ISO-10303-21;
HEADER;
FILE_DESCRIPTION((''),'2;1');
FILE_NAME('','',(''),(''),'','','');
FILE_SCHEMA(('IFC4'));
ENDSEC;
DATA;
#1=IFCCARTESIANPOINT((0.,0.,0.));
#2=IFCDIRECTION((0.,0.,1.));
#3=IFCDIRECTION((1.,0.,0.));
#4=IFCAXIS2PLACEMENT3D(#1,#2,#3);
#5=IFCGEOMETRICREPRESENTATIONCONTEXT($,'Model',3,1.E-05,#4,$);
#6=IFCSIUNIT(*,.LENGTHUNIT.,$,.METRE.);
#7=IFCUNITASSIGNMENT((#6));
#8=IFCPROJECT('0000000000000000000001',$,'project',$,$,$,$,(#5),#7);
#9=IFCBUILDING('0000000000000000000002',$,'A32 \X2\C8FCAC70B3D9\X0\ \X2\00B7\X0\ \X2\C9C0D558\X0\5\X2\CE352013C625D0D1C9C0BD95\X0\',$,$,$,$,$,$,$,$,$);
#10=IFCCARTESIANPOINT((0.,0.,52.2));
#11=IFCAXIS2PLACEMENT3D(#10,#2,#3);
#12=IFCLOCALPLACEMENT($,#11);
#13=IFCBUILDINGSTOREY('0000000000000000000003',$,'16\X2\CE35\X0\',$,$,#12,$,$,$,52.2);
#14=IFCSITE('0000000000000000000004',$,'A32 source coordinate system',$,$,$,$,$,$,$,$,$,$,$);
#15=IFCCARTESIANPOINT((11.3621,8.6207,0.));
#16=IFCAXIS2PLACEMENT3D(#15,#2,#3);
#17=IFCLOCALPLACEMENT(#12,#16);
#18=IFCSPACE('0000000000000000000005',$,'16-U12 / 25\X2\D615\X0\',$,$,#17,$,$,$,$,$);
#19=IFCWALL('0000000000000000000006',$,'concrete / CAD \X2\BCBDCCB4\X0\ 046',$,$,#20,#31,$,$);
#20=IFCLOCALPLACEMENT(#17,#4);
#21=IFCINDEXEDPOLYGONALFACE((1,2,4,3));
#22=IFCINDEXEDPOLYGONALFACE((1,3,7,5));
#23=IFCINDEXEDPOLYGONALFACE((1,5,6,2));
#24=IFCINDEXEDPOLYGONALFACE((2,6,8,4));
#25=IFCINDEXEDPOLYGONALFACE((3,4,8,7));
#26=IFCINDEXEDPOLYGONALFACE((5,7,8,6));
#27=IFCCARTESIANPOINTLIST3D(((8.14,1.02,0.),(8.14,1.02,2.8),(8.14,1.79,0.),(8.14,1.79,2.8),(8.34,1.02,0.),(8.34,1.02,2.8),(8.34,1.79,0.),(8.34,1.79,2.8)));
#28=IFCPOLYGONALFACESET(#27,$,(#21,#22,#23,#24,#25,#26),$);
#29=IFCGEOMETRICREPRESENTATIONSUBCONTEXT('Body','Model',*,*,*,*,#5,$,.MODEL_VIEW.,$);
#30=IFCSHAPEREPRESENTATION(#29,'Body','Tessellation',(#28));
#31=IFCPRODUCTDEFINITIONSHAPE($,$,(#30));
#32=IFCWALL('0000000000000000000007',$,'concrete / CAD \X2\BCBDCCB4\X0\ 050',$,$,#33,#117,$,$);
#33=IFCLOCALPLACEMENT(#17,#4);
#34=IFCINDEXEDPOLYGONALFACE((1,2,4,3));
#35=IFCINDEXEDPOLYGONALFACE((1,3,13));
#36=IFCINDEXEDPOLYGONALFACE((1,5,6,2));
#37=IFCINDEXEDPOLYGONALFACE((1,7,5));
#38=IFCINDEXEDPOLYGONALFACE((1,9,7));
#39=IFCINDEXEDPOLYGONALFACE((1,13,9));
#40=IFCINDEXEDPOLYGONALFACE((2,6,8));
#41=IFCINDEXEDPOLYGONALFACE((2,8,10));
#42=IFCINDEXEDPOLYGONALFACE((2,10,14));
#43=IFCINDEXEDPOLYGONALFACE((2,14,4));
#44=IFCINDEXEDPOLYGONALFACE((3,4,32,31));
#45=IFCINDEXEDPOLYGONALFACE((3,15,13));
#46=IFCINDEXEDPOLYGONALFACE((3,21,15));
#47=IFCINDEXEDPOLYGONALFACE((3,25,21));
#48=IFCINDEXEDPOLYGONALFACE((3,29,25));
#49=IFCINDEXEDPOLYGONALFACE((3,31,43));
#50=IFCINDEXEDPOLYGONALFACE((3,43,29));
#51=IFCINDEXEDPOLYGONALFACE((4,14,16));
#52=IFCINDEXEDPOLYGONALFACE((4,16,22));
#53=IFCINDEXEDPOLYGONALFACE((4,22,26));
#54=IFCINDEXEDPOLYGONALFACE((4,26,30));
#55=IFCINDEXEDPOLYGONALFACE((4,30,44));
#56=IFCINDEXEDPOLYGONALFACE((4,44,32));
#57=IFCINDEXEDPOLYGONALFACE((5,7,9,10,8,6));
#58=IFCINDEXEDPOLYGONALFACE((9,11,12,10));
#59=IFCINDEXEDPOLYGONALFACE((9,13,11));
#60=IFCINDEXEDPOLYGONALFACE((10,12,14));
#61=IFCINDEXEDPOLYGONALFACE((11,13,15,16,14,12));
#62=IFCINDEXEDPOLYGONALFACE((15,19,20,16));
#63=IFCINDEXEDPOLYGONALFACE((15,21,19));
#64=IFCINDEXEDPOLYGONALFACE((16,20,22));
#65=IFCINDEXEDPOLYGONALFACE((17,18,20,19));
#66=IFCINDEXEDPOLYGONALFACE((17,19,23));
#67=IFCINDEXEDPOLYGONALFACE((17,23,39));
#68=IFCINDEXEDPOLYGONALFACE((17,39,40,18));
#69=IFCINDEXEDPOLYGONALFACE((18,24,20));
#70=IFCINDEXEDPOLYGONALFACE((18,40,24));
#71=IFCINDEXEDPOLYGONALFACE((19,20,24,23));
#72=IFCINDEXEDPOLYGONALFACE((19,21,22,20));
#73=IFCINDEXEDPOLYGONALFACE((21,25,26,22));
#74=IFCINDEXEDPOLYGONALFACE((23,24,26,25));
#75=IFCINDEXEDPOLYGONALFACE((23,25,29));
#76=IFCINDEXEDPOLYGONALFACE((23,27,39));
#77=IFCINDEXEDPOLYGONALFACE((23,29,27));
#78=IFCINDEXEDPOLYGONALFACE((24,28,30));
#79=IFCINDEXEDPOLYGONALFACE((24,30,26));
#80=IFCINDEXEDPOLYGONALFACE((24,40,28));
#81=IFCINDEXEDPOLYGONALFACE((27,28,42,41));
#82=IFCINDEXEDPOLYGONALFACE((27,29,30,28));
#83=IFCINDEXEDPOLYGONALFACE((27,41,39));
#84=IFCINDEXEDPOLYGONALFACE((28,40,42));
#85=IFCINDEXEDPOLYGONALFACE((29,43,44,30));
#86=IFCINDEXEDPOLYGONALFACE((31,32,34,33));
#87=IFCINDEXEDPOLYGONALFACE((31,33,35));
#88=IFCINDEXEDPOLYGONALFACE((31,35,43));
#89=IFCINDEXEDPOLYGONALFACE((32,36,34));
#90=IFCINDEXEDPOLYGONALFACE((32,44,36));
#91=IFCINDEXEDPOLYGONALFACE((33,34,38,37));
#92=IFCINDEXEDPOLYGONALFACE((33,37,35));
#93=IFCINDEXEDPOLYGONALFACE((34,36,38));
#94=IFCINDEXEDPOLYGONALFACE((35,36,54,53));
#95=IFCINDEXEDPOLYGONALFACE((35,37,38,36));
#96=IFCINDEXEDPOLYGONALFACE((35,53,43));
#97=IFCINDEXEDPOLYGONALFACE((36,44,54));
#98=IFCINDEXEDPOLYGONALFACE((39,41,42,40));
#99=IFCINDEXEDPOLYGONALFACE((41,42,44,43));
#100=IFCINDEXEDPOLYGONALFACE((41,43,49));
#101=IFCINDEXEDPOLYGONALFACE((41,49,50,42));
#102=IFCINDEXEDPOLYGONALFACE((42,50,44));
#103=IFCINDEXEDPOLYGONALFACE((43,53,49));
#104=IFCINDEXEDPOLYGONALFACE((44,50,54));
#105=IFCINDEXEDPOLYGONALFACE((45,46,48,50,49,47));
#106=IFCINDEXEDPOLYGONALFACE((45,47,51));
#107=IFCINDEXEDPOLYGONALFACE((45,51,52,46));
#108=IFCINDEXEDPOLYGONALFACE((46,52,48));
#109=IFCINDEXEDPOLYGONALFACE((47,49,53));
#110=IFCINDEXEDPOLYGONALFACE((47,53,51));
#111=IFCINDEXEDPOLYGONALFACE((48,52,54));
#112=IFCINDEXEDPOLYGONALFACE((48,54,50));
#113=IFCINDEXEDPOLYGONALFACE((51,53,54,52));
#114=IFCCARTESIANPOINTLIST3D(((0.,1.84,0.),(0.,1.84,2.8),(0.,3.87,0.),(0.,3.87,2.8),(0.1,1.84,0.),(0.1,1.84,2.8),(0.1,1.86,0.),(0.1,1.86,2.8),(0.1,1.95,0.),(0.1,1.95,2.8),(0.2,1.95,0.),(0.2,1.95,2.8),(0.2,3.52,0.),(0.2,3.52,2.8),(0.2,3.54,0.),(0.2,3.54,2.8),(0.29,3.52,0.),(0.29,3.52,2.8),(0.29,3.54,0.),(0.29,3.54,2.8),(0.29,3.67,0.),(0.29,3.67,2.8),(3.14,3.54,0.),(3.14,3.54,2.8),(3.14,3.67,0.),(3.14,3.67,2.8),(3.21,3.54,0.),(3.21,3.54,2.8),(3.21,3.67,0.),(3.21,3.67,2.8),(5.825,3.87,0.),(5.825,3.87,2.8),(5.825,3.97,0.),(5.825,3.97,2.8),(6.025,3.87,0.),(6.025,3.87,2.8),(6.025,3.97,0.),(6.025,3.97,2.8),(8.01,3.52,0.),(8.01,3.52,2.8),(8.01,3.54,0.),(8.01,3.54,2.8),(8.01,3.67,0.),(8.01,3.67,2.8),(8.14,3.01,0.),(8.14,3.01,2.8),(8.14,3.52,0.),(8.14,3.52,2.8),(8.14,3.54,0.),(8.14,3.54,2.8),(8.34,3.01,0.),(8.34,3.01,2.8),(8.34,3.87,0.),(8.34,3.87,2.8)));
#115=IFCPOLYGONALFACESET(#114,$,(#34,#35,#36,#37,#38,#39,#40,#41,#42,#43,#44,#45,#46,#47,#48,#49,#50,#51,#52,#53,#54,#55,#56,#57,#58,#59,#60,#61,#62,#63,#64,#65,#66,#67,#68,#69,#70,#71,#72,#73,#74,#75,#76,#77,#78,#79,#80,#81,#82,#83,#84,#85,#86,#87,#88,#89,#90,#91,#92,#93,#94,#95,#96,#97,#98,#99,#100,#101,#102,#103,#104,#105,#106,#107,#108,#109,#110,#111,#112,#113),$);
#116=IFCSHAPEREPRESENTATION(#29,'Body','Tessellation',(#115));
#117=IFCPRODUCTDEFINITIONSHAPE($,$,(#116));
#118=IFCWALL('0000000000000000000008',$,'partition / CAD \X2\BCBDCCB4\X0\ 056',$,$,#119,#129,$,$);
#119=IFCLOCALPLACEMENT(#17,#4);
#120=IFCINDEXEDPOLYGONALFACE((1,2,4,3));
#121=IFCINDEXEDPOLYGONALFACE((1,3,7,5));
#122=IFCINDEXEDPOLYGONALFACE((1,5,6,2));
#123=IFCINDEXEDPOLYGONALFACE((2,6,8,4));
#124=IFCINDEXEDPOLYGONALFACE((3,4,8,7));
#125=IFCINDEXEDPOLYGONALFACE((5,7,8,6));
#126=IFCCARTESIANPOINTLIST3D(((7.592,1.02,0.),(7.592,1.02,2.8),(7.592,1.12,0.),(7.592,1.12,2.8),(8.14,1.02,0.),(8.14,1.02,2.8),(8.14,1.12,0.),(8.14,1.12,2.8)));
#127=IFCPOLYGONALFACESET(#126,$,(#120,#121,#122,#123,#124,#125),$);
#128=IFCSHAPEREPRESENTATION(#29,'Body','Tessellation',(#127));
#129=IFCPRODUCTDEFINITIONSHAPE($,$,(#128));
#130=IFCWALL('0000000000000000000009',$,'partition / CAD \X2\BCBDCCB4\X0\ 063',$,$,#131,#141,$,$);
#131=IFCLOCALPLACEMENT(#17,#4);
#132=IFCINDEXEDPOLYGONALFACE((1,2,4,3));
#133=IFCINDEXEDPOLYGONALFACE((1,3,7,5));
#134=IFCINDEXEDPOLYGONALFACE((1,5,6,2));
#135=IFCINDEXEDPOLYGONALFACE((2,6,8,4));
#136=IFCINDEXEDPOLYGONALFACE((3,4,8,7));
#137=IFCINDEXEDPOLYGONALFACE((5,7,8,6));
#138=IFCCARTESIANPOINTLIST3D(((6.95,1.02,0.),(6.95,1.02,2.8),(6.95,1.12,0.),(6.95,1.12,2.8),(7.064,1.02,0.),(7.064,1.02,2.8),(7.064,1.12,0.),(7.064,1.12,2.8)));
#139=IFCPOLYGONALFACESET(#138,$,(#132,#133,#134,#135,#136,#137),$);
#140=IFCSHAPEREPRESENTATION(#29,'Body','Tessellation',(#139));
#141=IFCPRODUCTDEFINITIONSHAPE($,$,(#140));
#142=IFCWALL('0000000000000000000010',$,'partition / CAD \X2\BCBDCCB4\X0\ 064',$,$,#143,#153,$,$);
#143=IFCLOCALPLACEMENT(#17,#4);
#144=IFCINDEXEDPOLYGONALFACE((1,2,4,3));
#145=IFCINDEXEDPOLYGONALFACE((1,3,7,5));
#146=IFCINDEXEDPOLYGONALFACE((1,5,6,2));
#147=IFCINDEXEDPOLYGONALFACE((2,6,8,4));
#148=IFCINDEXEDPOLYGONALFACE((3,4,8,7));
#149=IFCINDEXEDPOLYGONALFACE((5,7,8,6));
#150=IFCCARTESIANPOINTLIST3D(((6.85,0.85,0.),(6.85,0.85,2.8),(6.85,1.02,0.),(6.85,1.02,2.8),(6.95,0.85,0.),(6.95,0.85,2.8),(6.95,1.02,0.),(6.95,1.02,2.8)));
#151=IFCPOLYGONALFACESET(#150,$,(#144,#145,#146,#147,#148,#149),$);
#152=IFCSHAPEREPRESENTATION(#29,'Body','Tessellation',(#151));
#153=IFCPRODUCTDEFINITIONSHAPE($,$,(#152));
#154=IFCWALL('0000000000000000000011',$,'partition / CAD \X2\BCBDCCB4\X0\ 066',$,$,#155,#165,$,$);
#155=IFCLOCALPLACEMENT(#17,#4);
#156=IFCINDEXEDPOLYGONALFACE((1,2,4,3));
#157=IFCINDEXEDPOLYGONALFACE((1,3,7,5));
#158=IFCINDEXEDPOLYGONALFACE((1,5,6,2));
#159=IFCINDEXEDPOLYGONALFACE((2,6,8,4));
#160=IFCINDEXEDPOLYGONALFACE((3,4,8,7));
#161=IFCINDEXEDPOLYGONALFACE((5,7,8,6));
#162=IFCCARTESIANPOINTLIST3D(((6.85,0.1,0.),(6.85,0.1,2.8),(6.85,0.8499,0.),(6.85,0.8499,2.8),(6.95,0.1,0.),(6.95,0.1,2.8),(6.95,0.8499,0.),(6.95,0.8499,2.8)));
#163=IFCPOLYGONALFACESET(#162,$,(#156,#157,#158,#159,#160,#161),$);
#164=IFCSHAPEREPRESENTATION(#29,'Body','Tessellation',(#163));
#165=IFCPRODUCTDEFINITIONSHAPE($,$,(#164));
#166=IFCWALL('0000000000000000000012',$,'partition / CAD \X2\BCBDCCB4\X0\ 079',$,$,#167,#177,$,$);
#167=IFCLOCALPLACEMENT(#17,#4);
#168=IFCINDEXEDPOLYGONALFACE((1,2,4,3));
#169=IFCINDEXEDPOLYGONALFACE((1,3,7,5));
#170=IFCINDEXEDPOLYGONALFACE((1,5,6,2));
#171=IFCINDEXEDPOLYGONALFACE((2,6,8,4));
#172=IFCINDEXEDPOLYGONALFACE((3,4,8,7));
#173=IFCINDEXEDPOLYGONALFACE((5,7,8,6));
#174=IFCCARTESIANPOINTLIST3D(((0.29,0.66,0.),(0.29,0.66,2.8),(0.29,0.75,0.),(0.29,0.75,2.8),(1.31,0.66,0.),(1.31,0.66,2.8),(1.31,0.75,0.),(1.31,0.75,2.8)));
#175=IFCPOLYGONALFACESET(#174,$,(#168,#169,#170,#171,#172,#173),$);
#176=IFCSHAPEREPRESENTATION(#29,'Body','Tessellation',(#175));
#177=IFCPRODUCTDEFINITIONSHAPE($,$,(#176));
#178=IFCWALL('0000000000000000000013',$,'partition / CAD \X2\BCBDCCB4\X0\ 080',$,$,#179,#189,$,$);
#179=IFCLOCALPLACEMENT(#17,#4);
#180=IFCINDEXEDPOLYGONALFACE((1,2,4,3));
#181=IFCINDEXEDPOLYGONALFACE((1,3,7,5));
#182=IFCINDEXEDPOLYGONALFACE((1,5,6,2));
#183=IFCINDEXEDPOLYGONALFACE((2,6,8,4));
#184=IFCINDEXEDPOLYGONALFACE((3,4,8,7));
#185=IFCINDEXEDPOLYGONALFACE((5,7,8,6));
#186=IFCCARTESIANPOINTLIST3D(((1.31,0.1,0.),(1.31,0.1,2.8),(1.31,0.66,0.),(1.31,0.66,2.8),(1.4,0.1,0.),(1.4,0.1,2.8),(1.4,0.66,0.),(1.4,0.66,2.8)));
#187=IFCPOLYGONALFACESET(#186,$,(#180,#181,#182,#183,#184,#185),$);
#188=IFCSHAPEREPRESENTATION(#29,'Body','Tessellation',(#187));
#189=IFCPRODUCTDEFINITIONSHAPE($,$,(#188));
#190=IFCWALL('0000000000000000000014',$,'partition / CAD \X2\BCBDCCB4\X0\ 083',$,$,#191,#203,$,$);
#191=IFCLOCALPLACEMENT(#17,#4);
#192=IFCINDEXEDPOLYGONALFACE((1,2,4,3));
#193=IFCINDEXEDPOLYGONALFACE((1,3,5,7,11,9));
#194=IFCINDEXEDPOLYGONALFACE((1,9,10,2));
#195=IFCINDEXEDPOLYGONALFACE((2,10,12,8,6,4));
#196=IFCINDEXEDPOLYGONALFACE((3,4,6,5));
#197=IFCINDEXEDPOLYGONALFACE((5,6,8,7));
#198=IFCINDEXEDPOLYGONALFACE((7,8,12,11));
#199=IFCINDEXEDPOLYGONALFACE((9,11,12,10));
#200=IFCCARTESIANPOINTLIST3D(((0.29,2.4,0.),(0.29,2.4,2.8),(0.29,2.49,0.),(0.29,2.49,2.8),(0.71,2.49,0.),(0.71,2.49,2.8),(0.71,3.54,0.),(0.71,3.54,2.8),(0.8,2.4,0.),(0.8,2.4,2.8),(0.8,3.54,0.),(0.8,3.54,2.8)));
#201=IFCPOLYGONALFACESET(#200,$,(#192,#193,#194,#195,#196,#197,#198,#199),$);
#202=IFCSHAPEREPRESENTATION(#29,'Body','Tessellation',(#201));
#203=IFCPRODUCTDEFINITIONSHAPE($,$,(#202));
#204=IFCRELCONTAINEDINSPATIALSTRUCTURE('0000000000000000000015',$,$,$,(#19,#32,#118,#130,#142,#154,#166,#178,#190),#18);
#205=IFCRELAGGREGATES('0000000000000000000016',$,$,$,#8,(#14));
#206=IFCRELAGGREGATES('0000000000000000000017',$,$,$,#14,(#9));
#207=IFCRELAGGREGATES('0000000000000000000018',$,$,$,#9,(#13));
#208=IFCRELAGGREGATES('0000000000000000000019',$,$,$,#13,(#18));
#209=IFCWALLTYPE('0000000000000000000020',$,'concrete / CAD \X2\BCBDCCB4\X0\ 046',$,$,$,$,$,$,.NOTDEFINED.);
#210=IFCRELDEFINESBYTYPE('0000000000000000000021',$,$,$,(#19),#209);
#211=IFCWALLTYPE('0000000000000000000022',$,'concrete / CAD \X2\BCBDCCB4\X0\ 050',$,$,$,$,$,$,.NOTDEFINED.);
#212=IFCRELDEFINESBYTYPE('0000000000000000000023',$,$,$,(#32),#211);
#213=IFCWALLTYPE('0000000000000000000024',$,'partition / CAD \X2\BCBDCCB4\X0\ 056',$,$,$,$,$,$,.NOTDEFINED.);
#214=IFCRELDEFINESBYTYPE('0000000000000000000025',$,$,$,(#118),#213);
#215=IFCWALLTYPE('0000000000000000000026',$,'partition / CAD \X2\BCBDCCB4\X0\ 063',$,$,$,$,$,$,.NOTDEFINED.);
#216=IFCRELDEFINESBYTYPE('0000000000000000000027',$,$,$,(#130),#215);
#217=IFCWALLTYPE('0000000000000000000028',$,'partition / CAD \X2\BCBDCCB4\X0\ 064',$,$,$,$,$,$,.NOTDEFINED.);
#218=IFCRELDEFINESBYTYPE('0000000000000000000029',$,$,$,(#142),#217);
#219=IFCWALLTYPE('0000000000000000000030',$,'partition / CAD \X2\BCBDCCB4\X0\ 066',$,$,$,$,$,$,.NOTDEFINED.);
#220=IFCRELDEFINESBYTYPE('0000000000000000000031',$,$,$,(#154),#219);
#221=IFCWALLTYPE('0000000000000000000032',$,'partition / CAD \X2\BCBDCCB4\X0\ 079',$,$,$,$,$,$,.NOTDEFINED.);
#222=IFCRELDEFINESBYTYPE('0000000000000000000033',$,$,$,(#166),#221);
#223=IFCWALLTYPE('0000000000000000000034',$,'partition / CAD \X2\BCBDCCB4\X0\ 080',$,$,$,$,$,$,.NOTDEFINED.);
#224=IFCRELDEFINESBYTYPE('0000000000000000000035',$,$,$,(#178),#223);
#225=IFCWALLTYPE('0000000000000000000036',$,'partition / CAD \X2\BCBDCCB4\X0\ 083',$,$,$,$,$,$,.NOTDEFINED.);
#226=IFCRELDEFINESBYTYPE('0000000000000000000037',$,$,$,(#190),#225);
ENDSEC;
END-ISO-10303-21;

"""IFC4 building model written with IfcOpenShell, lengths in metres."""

from ifc_helpers import new_model, si_unit, frame, origin, origin_with_axes, place, context, subcontext, project, spatial, polyline, outline, extrude, source, transform, mapped, type_object, type_shapes, element, save


model = new_model("IFC4")

# Units and contexts
model_context = context("Model", 3, precision=1e-05, world=origin_with_axes())
body_context = subcontext(model_context, "Body", "Model", "MODEL_VIEW")
ifc_project = project(units=[si_unit("LENGTHUNIT", "METRE")], contexts=[model_context])

# Site, building, storey, space
site = spatial("IfcSite", under=ifc_project, Name="A32 source coordinate system")
building = spatial("IfcBuilding", under=site, Name="A32 주거동 · 지하5층–옥탑지붕")
storey_placement = place(None, frame((0.0, 0.0, 52.2), z_axis=(0.0, 0.0, 1.0), x_axis=(1.0, 0.0, 0.0)))
storey = spatial("IfcBuildingStorey", under=building, at=storey_placement, Name="16층", Elevation=52.2)
space_1_placement = place(storey_placement, frame((11.3621, 8.6207, 0.0), z_axis=(0.0, 0.0, 1.0), x_axis=(1.0, 0.0, 0.0)))
space_1 = spatial("IfcSpace", under=storey, at=space_1_placement, Name="16-U12 / 25형")

# Walls
wall_type_1 = type_object("IfcWallType", Name="concrete / CAD 벽체 046", PredefinedType="NOTDEFINED")
shared_shape_1 = source(origin(), body_context, "Body", "SweptSolid", [
    extrude(outline(polyline([(8.14, 1.02), (8.14, 1.79), (8.34, 1.79), (8.34, 1.02), (8.14, 1.02)])), origin(), (0.0, 0.0, 1.0), 2.8),
])
type_shapes(wall_type_1, [shared_shape_1])
wall_1_placement = place(space_1_placement, origin_with_axes())
element("IfcWall", 1, at=wall_1_placement, inside=space_1, type_object=wall_type_1, Name="concrete / CAD 벽체 046", context=body_context, shape_type="MappedRepresentation", body=[
    mapped(shared_shape_1, transform((0.0, 0.0, 0.0), scale=1.0)),
])
wall_type_2 = type_object("IfcWallType", Name="concrete / CAD 벽체 050", PredefinedType="NOTDEFINED")
shared_shape_2 = source(origin(), body_context, "Body", "SweptSolid", [
    extrude(outline(polyline([(8.01, 3.52), (0.29, 3.52), (0.29, 3.54), (0.2, 3.54), (0.2, 3.52), (0.2, 1.95), (0.1, 1.95), (0.1, 1.86), (0.1, 1.84), (0.0, 1.84), (0.0, 3.87), (5.825, 3.87), (5.825, 3.97), (6.025, 3.97), (6.025, 3.87), (8.34, 3.87), (8.34, 3.01), (8.14, 3.01), (8.14, 3.52), (8.14, 3.54), (8.01, 3.54), (8.01, 3.52)]), holes=[polyline([(3.14, 3.54), (3.14, 3.67), (0.29, 3.67), (0.29, 3.54), (3.14, 3.54)]), polyline([(8.01, 3.67), (3.21, 3.67), (3.21, 3.54), (8.01, 3.54), (8.01, 3.67)])]), origin(), (0.0, 0.0, 1.0), 2.8),
])
type_shapes(wall_type_2, [shared_shape_2])
wall_2_placement = place(space_1_placement, origin_with_axes())
element("IfcWall", 2, at=wall_2_placement, inside=space_1, type_object=wall_type_2, Name="concrete / CAD 벽체 050", context=body_context, shape_type="MappedRepresentation", body=[
    mapped(shared_shape_2, transform((0.0, 0.0, 0.0), scale=1.0)),
])
wall_type_3 = type_object("IfcWallType", Name="partition / CAD 벽체 056", PredefinedType="NOTDEFINED")
shared_shape_3 = source(origin(), body_context, "Body", "SweptSolid", [
    extrude(outline(polyline([(7.592, 1.12), (8.14, 1.12), (8.14, 1.02), (7.592, 1.02), (7.592, 1.12)])), origin(), (0.0, 0.0, 1.0), 2.8),
])
type_shapes(wall_type_3, [shared_shape_3])
wall_3_placement = place(space_1_placement, origin_with_axes())
element("IfcWall", 3, at=wall_3_placement, inside=space_1, type_object=wall_type_3, Name="partition / CAD 벽체 056", context=body_context, shape_type="MappedRepresentation", body=[
    mapped(shared_shape_3, transform((0.0, 0.0, 0.0), scale=1.0)),
])
wall_type_4 = type_object("IfcWallType", Name="partition / CAD 벽체 063", PredefinedType="NOTDEFINED")
shared_shape_4 = source(origin(), body_context, "Body", "SweptSolid", [
    extrude(outline(polyline([(6.95, 1.12), (7.064, 1.12), (7.064, 1.02), (6.95, 1.02), (6.95, 1.12)])), origin(), (0.0, 0.0, 1.0), 2.8),
])
type_shapes(wall_type_4, [shared_shape_4])
wall_4_placement = place(space_1_placement, origin_with_axes())
element("IfcWall", 4, at=wall_4_placement, inside=space_1, type_object=wall_type_4, Name="partition / CAD 벽체 063", context=body_context, shape_type="MappedRepresentation", body=[
    mapped(shared_shape_4, transform((0.0, 0.0, 0.0), scale=1.0)),
])
wall_type_5 = type_object("IfcWallType", Name="partition / CAD 벽체 064", PredefinedType="NOTDEFINED")
shared_shape_5 = source(origin(), body_context, "Body", "SweptSolid", [
    extrude(outline(polyline([(6.95, 0.85), (6.85, 0.85), (6.85, 1.02), (6.95, 1.02), (6.95, 0.85)])), origin(), (0.0, 0.0, 1.0), 2.8),
])
type_shapes(wall_type_5, [shared_shape_5])
wall_5_placement = place(space_1_placement, origin_with_axes())
element("IfcWall", 5, at=wall_5_placement, inside=space_1, type_object=wall_type_5, Name="partition / CAD 벽체 064", context=body_context, shape_type="MappedRepresentation", body=[
    mapped(shared_shape_5, transform((0.0, 0.0, 0.0), scale=1.0)),
])
wall_type_6 = type_object("IfcWallType", Name="partition / CAD 벽체 066", PredefinedType="NOTDEFINED")
shared_shape_6 = source(origin(), body_context, "Body", "SweptSolid", [
    extrude(outline(polyline([(6.85, 0.8499), (6.95, 0.8499), (6.95, 0.1), (6.85, 0.1), (6.85, 0.8499)])), origin(), (0.0, 0.0, 1.0), 2.8),
])
type_shapes(wall_type_6, [shared_shape_6])
wall_6_placement = place(space_1_placement, origin_with_axes())
element("IfcWall", 6, at=wall_6_placement, inside=space_1, type_object=wall_type_6, Name="partition / CAD 벽체 066", context=body_context, shape_type="MappedRepresentation", body=[
    mapped(shared_shape_6, transform((0.0, 0.0, 0.0), scale=1.0)),
])
wall_type_7 = type_object("IfcWallType", Name="partition / CAD 벽체 079", PredefinedType="NOTDEFINED")
shared_shape_7 = source(origin(), body_context, "Body", "SweptSolid", [
    extrude(outline(polyline([(0.29, 0.75), (1.31, 0.75), (1.31, 0.66), (0.29, 0.66), (0.29, 0.75)])), origin(), (0.0, 0.0, 1.0), 2.8),
])
type_shapes(wall_type_7, [shared_shape_7])
wall_7_placement = place(space_1_placement, origin_with_axes())
element("IfcWall", 7, at=wall_7_placement, inside=space_1, type_object=wall_type_7, Name="partition / CAD 벽체 079", context=body_context, shape_type="MappedRepresentation", body=[
    mapped(shared_shape_7, transform((0.0, 0.0, 0.0), scale=1.0)),
])
wall_type_8 = type_object("IfcWallType", Name="partition / CAD 벽체 080", PredefinedType="NOTDEFINED")
shared_shape_8 = source(origin(), body_context, "Body", "SweptSolid", [
    extrude(outline(polyline([(1.4, 0.66), (1.4, 0.1), (1.31, 0.1), (1.31, 0.66), (1.4, 0.66)])), origin(), (0.0, 0.0, 1.0), 2.8),
])
type_shapes(wall_type_8, [shared_shape_8])
wall_8_placement = place(space_1_placement, origin_with_axes())
element("IfcWall", 8, at=wall_8_placement, inside=space_1, type_object=wall_type_8, Name="partition / CAD 벽체 080", context=body_context, shape_type="MappedRepresentation", body=[
    mapped(shared_shape_8, transform((0.0, 0.0, 0.0), scale=1.0)),
])
wall_type_9 = type_object("IfcWallType", Name="partition / CAD 벽체 083", PredefinedType="NOTDEFINED")
shared_shape_9 = source(origin(), body_context, "Body", "SweptSolid", [
    extrude(outline(polyline([(0.71, 2.49), (0.71, 3.54), (0.8, 3.54), (0.8, 2.4), (0.29, 2.4), (0.29, 2.49), (0.71, 2.49)])), origin(), (0.0, 0.0, 1.0), 2.8),
])
type_shapes(wall_type_9, [shared_shape_9])
wall_9_placement = place(space_1_placement, origin_with_axes())
element("IfcWall", 9, at=wall_9_placement, inside=space_1, type_object=wall_type_9, Name="partition / CAD 벽체 083", context=body_context, shape_type="MappedRepresentation", body=[
    mapped(shared_shape_9, transform((0.0, 0.0, 0.0), scale=1.0)),
])

save(model, "model.ifc")
